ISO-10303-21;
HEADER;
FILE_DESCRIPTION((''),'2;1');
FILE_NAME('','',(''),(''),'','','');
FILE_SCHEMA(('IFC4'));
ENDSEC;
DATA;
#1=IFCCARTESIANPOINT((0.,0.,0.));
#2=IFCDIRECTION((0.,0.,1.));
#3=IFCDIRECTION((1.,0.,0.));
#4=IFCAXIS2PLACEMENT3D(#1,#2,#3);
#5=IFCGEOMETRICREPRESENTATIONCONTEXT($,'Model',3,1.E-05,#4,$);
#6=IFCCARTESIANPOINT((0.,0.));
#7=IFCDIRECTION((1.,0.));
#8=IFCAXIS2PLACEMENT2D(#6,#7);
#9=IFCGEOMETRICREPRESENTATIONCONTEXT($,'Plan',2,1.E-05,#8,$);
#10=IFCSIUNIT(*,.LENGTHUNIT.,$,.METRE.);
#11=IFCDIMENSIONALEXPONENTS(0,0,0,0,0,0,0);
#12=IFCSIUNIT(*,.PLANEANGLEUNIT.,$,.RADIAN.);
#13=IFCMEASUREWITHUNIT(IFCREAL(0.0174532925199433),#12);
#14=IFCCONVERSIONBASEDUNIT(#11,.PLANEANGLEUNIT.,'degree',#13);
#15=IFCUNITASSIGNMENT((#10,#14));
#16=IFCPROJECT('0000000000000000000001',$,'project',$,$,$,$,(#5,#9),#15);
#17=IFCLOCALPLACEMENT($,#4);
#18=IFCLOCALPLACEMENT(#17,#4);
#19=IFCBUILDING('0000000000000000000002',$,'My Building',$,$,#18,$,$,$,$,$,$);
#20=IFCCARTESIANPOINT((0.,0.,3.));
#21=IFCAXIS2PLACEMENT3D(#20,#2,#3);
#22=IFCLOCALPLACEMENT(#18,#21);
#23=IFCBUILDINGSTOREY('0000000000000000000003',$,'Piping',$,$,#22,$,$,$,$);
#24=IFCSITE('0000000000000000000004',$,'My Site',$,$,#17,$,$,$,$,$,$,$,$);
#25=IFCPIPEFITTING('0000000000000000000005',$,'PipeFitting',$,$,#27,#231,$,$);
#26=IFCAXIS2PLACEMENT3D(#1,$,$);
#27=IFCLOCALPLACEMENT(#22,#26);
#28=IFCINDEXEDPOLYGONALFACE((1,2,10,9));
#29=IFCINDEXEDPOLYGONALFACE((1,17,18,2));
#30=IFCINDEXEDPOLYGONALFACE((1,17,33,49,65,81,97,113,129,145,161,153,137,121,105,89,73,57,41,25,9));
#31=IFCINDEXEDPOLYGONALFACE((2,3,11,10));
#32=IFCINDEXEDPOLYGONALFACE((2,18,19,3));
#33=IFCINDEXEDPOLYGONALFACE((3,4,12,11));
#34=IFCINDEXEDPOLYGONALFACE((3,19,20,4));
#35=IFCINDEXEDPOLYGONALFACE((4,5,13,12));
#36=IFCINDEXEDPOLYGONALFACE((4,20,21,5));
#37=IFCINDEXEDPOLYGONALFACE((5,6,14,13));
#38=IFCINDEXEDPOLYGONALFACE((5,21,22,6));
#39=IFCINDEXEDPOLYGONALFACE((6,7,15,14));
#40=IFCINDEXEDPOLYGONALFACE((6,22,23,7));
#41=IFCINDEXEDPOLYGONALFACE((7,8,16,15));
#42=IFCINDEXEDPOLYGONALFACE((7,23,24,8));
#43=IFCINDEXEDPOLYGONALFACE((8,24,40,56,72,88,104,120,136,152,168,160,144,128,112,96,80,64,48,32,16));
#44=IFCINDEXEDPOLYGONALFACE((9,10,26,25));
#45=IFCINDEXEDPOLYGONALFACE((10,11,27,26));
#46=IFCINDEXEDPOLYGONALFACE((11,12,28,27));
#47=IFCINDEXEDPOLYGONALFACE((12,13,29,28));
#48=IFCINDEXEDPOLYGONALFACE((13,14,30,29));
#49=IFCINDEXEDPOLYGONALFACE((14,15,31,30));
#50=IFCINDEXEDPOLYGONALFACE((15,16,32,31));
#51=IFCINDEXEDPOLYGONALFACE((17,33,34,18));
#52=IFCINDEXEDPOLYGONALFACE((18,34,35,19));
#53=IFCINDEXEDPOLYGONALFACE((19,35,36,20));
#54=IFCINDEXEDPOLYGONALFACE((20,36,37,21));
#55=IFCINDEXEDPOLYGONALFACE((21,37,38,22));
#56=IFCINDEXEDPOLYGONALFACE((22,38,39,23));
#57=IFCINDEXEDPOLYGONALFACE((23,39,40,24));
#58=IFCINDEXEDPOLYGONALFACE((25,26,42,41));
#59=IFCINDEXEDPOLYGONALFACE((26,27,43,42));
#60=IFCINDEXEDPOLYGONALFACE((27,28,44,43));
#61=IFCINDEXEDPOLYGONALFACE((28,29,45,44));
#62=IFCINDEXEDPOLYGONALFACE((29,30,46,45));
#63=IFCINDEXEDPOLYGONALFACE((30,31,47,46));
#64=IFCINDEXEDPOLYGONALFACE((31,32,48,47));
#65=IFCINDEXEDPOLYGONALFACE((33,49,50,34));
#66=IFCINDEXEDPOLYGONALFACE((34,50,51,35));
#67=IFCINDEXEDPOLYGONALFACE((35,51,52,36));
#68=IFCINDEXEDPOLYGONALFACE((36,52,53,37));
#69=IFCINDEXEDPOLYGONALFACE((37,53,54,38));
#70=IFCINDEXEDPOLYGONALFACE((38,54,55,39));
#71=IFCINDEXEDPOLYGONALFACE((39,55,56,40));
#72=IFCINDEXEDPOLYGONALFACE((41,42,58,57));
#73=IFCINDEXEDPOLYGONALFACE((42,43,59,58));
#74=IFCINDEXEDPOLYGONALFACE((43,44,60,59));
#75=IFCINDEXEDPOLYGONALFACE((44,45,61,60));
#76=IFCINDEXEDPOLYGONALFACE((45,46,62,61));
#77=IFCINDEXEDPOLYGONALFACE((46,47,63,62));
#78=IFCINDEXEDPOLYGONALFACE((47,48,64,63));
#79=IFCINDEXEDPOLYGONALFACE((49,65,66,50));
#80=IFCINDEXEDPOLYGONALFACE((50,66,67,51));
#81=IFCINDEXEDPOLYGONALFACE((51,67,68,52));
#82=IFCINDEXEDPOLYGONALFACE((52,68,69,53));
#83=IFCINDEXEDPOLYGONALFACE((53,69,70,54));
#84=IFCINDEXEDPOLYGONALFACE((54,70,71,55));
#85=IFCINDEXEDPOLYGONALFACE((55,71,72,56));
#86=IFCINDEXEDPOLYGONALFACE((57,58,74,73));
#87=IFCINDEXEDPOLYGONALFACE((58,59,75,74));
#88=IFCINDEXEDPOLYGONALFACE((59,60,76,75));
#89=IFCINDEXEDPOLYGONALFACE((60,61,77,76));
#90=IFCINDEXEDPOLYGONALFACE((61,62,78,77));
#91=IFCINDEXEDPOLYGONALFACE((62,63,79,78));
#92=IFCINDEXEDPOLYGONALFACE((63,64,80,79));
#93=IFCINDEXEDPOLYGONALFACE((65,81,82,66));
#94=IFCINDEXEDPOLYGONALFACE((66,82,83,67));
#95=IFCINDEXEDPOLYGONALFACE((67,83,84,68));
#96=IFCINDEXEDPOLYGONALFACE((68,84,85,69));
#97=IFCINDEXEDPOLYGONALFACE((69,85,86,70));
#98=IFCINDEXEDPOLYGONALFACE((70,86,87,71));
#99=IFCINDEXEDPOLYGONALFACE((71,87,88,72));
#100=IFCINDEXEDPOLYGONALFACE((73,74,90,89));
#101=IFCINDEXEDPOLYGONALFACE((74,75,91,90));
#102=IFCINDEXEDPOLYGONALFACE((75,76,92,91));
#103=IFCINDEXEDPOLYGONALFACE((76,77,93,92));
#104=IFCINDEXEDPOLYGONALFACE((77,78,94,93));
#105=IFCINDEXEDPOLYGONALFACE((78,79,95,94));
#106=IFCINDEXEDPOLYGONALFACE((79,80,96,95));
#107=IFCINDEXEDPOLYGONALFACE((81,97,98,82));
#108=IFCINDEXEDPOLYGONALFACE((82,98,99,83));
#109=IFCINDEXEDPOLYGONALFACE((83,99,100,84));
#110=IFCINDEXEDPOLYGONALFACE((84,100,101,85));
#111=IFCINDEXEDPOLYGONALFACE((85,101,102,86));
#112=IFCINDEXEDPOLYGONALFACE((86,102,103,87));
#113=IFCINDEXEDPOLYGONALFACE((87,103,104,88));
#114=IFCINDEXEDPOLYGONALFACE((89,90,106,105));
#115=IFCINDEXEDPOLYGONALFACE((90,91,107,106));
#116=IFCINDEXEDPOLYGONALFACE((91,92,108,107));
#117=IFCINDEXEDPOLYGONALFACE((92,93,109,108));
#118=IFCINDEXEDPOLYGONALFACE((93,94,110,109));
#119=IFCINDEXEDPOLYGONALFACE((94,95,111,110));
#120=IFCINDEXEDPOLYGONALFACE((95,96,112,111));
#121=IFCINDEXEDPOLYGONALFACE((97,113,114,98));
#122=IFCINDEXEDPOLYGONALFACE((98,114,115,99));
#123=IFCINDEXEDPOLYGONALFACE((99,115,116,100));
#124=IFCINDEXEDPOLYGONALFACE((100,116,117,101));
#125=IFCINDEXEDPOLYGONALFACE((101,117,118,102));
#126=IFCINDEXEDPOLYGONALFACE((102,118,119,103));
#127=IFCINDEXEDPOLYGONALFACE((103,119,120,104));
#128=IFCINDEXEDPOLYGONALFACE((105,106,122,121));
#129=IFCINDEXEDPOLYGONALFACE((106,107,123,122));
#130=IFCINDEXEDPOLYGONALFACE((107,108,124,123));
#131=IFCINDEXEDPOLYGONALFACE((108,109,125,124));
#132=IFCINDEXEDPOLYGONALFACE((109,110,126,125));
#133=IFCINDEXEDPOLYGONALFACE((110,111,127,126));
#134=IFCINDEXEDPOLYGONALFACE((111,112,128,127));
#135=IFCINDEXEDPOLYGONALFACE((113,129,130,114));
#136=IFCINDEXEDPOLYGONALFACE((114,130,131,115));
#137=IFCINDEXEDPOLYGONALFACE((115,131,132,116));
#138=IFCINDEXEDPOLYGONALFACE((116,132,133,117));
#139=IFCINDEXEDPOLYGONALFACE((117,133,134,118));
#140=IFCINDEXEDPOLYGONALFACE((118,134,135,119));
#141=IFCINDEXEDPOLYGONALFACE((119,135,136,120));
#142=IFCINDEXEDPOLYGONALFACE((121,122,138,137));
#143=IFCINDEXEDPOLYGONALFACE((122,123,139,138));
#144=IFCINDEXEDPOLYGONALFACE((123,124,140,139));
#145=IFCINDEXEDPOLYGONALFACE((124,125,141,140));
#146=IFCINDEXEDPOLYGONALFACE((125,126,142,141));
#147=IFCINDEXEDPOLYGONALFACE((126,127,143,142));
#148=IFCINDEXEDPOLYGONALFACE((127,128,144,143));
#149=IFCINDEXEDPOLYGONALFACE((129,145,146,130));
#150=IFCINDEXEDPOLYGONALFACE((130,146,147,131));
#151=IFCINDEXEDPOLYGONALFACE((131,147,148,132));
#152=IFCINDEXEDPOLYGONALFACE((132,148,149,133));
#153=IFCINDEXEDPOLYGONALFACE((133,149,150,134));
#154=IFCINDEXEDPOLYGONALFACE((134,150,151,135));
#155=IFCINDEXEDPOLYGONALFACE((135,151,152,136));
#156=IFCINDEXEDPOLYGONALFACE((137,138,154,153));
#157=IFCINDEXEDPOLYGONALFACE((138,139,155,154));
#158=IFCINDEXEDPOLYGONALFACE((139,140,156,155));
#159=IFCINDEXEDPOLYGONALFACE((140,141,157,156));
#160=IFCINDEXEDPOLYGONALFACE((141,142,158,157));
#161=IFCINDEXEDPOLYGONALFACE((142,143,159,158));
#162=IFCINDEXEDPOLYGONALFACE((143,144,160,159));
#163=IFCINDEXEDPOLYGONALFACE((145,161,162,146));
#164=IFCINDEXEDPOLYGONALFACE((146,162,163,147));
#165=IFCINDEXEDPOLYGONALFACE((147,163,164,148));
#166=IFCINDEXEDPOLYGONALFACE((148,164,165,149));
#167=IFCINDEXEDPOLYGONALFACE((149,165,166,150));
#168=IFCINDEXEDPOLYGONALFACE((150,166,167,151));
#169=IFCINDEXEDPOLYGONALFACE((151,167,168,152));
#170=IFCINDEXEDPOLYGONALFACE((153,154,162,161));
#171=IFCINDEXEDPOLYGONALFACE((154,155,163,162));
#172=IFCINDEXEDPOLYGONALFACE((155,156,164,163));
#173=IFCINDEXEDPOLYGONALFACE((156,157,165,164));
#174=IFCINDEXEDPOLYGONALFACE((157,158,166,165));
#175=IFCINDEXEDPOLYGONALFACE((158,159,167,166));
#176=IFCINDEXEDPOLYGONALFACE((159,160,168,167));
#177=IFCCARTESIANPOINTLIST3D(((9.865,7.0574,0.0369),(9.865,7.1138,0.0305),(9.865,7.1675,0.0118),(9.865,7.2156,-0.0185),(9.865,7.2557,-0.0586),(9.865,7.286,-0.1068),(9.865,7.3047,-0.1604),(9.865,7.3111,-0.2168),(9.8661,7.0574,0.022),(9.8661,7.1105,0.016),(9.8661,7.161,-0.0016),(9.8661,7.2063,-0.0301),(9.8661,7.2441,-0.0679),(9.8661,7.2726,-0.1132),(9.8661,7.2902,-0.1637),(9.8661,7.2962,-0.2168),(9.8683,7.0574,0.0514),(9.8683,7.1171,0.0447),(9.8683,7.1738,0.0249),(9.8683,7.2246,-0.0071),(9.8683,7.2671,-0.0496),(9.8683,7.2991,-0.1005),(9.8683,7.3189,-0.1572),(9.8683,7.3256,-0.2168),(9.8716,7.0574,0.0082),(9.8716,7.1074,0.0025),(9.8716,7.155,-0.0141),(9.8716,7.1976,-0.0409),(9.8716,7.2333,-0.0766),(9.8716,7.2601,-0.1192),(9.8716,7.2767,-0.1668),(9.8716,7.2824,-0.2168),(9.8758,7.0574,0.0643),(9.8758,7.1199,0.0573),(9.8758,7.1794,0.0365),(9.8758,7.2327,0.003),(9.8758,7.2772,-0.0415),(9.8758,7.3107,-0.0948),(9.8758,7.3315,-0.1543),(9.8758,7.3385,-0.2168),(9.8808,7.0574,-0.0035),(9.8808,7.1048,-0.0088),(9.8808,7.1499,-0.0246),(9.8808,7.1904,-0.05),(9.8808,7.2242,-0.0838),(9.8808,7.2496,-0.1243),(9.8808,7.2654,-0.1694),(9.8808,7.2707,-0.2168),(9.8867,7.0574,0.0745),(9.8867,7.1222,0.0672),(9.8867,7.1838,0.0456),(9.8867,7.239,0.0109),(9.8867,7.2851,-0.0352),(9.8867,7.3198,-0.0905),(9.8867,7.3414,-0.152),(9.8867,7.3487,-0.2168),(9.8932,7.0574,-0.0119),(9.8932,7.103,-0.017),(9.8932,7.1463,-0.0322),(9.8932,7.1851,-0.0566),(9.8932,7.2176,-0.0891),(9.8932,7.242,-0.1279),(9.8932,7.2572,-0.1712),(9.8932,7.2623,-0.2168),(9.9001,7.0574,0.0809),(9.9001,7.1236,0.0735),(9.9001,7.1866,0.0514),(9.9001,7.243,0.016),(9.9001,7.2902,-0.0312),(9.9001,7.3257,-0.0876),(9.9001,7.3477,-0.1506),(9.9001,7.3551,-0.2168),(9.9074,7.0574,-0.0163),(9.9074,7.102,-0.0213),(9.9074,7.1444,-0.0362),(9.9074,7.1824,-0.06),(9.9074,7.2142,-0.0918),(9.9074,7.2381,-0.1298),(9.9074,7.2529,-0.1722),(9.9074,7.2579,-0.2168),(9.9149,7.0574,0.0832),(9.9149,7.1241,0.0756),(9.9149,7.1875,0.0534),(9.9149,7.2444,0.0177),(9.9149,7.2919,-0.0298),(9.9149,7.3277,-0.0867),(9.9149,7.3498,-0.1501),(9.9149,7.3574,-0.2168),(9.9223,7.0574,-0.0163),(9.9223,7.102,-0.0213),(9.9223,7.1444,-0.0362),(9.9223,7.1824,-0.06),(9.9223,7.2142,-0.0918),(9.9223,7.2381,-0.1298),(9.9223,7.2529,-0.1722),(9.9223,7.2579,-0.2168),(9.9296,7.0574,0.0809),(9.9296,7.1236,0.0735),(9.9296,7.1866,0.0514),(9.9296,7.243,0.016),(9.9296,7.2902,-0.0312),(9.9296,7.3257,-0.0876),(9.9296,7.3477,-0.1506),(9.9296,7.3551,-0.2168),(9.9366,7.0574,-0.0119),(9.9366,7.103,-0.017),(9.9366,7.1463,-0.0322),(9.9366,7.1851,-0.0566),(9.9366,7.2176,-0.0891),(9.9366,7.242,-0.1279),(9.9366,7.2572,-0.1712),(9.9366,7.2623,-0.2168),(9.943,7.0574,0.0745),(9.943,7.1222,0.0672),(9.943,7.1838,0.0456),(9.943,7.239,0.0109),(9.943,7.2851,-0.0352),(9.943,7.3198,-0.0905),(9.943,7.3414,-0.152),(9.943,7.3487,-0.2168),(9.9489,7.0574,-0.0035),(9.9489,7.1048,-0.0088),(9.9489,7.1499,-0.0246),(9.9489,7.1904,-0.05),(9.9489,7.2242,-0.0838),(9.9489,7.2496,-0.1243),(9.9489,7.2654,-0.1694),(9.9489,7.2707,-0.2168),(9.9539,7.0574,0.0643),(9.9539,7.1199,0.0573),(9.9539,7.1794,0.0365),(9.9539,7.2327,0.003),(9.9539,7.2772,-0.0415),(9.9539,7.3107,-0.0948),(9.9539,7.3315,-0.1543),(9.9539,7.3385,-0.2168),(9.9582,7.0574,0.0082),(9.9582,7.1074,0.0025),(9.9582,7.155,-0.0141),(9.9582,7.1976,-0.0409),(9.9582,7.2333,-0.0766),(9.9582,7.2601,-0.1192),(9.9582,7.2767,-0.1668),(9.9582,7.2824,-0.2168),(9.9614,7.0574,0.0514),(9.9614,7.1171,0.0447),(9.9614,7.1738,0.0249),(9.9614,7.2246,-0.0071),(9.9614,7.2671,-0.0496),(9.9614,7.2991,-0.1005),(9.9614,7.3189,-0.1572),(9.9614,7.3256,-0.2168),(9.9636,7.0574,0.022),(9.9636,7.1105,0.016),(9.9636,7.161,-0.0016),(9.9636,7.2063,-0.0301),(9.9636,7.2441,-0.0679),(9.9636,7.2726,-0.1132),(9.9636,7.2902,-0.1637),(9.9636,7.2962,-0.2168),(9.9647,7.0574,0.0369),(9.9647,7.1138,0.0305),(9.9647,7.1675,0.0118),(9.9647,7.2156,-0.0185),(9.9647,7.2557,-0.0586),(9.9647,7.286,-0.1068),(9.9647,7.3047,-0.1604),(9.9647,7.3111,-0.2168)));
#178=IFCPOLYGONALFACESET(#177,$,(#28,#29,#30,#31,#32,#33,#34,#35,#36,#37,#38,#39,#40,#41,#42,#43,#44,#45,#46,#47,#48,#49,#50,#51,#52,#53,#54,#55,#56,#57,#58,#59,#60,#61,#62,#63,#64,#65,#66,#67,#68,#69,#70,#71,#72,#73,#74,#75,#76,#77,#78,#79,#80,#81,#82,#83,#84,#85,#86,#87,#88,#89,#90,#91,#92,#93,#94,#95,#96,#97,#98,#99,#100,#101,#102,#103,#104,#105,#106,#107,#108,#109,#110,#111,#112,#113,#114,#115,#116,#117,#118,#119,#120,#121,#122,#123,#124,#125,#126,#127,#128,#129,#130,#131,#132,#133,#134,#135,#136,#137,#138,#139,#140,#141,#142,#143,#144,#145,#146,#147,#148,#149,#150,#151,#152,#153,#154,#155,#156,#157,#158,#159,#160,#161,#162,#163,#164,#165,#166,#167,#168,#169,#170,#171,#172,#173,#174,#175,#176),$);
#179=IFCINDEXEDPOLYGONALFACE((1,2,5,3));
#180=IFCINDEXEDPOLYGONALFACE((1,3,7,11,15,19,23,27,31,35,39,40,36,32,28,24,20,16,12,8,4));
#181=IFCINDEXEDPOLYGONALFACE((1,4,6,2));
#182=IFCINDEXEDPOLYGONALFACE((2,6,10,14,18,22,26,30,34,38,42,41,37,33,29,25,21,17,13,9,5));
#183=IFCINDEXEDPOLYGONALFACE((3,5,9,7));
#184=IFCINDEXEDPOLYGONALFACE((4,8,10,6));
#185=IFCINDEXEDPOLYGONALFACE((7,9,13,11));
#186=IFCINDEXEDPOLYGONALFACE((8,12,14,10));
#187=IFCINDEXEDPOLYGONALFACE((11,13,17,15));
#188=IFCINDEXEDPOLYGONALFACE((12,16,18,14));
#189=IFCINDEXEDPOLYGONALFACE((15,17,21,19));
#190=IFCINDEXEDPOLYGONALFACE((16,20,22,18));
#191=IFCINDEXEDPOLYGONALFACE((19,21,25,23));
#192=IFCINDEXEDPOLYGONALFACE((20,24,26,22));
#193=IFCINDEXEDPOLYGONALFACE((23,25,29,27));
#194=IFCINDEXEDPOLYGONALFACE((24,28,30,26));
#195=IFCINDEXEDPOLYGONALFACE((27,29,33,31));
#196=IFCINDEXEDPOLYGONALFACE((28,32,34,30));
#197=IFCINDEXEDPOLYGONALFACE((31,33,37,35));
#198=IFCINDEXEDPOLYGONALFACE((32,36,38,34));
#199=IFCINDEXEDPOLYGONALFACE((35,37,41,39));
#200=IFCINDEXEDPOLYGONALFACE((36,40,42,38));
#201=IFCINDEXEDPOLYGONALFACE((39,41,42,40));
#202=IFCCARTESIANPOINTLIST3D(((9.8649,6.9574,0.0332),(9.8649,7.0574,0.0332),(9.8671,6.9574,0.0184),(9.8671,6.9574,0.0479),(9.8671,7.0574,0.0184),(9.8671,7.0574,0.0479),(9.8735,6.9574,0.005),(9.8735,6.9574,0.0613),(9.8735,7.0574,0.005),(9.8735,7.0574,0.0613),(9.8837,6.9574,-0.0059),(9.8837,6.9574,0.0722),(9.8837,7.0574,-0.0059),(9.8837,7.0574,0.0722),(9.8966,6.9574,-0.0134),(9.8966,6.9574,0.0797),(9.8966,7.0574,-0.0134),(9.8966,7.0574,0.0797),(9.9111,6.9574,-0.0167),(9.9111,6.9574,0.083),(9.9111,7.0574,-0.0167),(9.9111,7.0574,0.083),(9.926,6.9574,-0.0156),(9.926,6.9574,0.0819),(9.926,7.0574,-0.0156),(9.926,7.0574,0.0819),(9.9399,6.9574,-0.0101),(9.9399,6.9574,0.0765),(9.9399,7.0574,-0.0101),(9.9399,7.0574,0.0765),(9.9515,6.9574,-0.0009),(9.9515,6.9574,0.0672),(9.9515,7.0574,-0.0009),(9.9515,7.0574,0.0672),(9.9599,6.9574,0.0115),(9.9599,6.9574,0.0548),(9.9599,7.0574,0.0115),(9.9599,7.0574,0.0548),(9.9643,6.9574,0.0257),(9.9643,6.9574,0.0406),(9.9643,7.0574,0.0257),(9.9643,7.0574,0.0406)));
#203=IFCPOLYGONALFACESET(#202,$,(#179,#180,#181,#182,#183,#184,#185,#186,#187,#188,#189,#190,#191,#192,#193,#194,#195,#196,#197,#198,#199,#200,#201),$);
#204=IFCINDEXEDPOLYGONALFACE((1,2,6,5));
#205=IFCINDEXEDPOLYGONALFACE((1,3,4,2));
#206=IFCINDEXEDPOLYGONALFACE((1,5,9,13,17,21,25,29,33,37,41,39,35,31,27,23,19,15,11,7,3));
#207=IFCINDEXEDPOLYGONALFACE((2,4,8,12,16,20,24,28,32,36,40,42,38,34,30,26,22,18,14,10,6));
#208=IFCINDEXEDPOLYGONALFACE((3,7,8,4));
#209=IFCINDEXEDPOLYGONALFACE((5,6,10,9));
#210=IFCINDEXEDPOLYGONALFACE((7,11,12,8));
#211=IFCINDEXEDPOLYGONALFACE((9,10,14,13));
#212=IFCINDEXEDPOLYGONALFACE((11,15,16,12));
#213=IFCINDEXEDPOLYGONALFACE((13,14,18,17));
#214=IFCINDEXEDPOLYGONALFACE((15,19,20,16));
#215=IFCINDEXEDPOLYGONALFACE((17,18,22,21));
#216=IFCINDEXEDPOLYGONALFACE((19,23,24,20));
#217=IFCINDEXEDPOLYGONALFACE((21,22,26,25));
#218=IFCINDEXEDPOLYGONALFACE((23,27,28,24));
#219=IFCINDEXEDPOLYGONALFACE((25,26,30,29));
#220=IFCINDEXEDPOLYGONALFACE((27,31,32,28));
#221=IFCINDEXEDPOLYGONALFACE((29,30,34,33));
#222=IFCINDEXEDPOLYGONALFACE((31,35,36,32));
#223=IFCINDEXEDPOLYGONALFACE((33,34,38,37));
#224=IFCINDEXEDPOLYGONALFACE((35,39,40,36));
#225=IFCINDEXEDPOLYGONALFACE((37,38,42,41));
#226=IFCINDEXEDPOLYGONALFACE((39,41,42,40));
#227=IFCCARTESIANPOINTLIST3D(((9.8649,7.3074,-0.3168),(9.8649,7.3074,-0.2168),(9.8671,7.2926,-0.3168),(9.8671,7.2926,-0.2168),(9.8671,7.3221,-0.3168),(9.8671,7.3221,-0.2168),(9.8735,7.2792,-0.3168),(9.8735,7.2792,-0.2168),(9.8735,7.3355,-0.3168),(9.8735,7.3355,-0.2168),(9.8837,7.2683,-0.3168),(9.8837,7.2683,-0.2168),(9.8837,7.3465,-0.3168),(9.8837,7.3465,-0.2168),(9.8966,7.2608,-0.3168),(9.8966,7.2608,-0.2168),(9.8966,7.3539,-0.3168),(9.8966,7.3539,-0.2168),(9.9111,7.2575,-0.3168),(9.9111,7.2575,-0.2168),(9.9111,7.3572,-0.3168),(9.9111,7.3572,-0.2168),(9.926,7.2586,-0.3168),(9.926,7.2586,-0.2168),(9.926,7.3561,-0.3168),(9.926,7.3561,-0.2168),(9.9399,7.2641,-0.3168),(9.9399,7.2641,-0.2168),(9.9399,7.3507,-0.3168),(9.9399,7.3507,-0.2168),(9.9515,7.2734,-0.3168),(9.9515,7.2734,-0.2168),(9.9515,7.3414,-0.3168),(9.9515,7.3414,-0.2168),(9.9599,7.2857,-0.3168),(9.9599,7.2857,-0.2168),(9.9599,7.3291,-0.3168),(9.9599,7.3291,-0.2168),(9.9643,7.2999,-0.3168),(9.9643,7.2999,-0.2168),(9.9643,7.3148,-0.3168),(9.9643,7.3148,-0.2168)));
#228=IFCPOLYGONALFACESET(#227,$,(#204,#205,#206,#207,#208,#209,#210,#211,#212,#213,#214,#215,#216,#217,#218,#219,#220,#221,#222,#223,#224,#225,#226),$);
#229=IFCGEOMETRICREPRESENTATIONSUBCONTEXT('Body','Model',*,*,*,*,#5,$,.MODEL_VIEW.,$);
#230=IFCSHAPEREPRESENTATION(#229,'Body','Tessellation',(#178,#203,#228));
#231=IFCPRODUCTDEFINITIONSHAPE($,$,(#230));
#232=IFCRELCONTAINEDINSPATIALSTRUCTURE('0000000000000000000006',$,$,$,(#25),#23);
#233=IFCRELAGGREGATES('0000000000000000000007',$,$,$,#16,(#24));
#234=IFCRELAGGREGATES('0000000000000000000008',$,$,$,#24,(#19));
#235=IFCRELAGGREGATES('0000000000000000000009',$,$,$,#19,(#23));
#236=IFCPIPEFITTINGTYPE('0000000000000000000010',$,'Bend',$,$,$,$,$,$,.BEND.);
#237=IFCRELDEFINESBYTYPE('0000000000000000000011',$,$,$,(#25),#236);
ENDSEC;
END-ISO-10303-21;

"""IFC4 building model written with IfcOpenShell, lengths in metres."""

from ifc_helpers import new_model, entity, si_unit, converted_unit, frame, origin_with_axes, origin_2d_with_axis, place, context, subcontext, project, spatial, circle, extrude, source, transform, mapped, type_object, type_shapes, element, save


model = new_model("IFC4")

# Units and contexts
model_context = context("Model", 3, precision=1e-05, world=origin_with_axes())
plan_context = context("Plan", 2, precision=1e-05, world=origin_2d_with_axis())
body_context = subcontext(model_context, "Body", "Model", "MODEL_VIEW")
ifc_project = project(units=[si_unit("LENGTHUNIT", "METRE"), converted_unit("PLANEANGLEUNIT", "degree", entity("IfcReal", 0.0174532925199433), si_unit("PLANEANGLEUNIT", "RADIAN"), dimensions=[0, 0, 0, 0, 0, 0, 0])], contexts=[model_context, plan_context])

# Site, building, storey
site_placement = place(None, origin_with_axes())
site = spatial("IfcSite", under=ifc_project, at=site_placement, Name="My Site")
building_placement = place(site_placement, origin_with_axes())
building = spatial("IfcBuilding", under=site, at=building_placement, Name="My Building")
storey_placement = place(building_placement, frame((0.0, 0.0, 3.0), z_axis=(0.0, 0.0, 1.0), x_axis=(1.0, 0.0, 0.0)))
storey = spatial("IfcBuildingStorey", under=building, at=storey_placement, Name="Piping")

# Pipe fitting
pipe_fitting_type = type_object("IfcPipeFittingType", Name="Bend", PredefinedType="BEND")
shared_shape = source(origin_with_axes(), body_context, "Body", "SolidModel", [
    entity("IfcSweptDiskSolid", entity("IfcIndexedPolyCurve", entity("IfcCartesianPointList3D", [[0.0, 0.0, -0.1], [0.0, 0.0732, -0.2768], [0.0, 0.25, -0.35]]), [entity("IfcArcIndex", [1, 2, 3])]), 0.05),
    extrude(circle(Radius=0.05), origin_with_axes(), (0.0, 0.0, -1.0), 0.1),
    extrude(circle(Radius=0.05), frame((0.0, 0.25, -0.35), z_axis=(0.0, 1.0, 0.0), x_axis=(1.0, 0.0, 0.0)), (0.0, 0.0, 1.0), 0.1),
])
type_shapes(pipe_fitting_type, [shared_shape])
for number, where, z_axis, x_axis, name in (
    (1, (9.9149, 6.9574, 0.0332), (0.0, -1.0, 0.0), (-1.0, 0.0, 0.0), "PipeFitting"),
):
    element("IfcPipeFitting", number, at=place(storey_placement, frame(where, z_axis=z_axis, x_axis=x_axis)), inside=storey, type_object=pipe_fitting_type, Name=name, context=body_context, shape_type="MappedRepresentation", body=[
        mapped(shared_shape, transform((0.0, 0.0, 0.0), x_axis=(1.0, 0.0, 0.0), y_axis=(0.0, 1.0, 0.0), z_axis=(0.0, 0.0, 1.0), scale=1.0)),
    ])

save(model, "model.ifc")
